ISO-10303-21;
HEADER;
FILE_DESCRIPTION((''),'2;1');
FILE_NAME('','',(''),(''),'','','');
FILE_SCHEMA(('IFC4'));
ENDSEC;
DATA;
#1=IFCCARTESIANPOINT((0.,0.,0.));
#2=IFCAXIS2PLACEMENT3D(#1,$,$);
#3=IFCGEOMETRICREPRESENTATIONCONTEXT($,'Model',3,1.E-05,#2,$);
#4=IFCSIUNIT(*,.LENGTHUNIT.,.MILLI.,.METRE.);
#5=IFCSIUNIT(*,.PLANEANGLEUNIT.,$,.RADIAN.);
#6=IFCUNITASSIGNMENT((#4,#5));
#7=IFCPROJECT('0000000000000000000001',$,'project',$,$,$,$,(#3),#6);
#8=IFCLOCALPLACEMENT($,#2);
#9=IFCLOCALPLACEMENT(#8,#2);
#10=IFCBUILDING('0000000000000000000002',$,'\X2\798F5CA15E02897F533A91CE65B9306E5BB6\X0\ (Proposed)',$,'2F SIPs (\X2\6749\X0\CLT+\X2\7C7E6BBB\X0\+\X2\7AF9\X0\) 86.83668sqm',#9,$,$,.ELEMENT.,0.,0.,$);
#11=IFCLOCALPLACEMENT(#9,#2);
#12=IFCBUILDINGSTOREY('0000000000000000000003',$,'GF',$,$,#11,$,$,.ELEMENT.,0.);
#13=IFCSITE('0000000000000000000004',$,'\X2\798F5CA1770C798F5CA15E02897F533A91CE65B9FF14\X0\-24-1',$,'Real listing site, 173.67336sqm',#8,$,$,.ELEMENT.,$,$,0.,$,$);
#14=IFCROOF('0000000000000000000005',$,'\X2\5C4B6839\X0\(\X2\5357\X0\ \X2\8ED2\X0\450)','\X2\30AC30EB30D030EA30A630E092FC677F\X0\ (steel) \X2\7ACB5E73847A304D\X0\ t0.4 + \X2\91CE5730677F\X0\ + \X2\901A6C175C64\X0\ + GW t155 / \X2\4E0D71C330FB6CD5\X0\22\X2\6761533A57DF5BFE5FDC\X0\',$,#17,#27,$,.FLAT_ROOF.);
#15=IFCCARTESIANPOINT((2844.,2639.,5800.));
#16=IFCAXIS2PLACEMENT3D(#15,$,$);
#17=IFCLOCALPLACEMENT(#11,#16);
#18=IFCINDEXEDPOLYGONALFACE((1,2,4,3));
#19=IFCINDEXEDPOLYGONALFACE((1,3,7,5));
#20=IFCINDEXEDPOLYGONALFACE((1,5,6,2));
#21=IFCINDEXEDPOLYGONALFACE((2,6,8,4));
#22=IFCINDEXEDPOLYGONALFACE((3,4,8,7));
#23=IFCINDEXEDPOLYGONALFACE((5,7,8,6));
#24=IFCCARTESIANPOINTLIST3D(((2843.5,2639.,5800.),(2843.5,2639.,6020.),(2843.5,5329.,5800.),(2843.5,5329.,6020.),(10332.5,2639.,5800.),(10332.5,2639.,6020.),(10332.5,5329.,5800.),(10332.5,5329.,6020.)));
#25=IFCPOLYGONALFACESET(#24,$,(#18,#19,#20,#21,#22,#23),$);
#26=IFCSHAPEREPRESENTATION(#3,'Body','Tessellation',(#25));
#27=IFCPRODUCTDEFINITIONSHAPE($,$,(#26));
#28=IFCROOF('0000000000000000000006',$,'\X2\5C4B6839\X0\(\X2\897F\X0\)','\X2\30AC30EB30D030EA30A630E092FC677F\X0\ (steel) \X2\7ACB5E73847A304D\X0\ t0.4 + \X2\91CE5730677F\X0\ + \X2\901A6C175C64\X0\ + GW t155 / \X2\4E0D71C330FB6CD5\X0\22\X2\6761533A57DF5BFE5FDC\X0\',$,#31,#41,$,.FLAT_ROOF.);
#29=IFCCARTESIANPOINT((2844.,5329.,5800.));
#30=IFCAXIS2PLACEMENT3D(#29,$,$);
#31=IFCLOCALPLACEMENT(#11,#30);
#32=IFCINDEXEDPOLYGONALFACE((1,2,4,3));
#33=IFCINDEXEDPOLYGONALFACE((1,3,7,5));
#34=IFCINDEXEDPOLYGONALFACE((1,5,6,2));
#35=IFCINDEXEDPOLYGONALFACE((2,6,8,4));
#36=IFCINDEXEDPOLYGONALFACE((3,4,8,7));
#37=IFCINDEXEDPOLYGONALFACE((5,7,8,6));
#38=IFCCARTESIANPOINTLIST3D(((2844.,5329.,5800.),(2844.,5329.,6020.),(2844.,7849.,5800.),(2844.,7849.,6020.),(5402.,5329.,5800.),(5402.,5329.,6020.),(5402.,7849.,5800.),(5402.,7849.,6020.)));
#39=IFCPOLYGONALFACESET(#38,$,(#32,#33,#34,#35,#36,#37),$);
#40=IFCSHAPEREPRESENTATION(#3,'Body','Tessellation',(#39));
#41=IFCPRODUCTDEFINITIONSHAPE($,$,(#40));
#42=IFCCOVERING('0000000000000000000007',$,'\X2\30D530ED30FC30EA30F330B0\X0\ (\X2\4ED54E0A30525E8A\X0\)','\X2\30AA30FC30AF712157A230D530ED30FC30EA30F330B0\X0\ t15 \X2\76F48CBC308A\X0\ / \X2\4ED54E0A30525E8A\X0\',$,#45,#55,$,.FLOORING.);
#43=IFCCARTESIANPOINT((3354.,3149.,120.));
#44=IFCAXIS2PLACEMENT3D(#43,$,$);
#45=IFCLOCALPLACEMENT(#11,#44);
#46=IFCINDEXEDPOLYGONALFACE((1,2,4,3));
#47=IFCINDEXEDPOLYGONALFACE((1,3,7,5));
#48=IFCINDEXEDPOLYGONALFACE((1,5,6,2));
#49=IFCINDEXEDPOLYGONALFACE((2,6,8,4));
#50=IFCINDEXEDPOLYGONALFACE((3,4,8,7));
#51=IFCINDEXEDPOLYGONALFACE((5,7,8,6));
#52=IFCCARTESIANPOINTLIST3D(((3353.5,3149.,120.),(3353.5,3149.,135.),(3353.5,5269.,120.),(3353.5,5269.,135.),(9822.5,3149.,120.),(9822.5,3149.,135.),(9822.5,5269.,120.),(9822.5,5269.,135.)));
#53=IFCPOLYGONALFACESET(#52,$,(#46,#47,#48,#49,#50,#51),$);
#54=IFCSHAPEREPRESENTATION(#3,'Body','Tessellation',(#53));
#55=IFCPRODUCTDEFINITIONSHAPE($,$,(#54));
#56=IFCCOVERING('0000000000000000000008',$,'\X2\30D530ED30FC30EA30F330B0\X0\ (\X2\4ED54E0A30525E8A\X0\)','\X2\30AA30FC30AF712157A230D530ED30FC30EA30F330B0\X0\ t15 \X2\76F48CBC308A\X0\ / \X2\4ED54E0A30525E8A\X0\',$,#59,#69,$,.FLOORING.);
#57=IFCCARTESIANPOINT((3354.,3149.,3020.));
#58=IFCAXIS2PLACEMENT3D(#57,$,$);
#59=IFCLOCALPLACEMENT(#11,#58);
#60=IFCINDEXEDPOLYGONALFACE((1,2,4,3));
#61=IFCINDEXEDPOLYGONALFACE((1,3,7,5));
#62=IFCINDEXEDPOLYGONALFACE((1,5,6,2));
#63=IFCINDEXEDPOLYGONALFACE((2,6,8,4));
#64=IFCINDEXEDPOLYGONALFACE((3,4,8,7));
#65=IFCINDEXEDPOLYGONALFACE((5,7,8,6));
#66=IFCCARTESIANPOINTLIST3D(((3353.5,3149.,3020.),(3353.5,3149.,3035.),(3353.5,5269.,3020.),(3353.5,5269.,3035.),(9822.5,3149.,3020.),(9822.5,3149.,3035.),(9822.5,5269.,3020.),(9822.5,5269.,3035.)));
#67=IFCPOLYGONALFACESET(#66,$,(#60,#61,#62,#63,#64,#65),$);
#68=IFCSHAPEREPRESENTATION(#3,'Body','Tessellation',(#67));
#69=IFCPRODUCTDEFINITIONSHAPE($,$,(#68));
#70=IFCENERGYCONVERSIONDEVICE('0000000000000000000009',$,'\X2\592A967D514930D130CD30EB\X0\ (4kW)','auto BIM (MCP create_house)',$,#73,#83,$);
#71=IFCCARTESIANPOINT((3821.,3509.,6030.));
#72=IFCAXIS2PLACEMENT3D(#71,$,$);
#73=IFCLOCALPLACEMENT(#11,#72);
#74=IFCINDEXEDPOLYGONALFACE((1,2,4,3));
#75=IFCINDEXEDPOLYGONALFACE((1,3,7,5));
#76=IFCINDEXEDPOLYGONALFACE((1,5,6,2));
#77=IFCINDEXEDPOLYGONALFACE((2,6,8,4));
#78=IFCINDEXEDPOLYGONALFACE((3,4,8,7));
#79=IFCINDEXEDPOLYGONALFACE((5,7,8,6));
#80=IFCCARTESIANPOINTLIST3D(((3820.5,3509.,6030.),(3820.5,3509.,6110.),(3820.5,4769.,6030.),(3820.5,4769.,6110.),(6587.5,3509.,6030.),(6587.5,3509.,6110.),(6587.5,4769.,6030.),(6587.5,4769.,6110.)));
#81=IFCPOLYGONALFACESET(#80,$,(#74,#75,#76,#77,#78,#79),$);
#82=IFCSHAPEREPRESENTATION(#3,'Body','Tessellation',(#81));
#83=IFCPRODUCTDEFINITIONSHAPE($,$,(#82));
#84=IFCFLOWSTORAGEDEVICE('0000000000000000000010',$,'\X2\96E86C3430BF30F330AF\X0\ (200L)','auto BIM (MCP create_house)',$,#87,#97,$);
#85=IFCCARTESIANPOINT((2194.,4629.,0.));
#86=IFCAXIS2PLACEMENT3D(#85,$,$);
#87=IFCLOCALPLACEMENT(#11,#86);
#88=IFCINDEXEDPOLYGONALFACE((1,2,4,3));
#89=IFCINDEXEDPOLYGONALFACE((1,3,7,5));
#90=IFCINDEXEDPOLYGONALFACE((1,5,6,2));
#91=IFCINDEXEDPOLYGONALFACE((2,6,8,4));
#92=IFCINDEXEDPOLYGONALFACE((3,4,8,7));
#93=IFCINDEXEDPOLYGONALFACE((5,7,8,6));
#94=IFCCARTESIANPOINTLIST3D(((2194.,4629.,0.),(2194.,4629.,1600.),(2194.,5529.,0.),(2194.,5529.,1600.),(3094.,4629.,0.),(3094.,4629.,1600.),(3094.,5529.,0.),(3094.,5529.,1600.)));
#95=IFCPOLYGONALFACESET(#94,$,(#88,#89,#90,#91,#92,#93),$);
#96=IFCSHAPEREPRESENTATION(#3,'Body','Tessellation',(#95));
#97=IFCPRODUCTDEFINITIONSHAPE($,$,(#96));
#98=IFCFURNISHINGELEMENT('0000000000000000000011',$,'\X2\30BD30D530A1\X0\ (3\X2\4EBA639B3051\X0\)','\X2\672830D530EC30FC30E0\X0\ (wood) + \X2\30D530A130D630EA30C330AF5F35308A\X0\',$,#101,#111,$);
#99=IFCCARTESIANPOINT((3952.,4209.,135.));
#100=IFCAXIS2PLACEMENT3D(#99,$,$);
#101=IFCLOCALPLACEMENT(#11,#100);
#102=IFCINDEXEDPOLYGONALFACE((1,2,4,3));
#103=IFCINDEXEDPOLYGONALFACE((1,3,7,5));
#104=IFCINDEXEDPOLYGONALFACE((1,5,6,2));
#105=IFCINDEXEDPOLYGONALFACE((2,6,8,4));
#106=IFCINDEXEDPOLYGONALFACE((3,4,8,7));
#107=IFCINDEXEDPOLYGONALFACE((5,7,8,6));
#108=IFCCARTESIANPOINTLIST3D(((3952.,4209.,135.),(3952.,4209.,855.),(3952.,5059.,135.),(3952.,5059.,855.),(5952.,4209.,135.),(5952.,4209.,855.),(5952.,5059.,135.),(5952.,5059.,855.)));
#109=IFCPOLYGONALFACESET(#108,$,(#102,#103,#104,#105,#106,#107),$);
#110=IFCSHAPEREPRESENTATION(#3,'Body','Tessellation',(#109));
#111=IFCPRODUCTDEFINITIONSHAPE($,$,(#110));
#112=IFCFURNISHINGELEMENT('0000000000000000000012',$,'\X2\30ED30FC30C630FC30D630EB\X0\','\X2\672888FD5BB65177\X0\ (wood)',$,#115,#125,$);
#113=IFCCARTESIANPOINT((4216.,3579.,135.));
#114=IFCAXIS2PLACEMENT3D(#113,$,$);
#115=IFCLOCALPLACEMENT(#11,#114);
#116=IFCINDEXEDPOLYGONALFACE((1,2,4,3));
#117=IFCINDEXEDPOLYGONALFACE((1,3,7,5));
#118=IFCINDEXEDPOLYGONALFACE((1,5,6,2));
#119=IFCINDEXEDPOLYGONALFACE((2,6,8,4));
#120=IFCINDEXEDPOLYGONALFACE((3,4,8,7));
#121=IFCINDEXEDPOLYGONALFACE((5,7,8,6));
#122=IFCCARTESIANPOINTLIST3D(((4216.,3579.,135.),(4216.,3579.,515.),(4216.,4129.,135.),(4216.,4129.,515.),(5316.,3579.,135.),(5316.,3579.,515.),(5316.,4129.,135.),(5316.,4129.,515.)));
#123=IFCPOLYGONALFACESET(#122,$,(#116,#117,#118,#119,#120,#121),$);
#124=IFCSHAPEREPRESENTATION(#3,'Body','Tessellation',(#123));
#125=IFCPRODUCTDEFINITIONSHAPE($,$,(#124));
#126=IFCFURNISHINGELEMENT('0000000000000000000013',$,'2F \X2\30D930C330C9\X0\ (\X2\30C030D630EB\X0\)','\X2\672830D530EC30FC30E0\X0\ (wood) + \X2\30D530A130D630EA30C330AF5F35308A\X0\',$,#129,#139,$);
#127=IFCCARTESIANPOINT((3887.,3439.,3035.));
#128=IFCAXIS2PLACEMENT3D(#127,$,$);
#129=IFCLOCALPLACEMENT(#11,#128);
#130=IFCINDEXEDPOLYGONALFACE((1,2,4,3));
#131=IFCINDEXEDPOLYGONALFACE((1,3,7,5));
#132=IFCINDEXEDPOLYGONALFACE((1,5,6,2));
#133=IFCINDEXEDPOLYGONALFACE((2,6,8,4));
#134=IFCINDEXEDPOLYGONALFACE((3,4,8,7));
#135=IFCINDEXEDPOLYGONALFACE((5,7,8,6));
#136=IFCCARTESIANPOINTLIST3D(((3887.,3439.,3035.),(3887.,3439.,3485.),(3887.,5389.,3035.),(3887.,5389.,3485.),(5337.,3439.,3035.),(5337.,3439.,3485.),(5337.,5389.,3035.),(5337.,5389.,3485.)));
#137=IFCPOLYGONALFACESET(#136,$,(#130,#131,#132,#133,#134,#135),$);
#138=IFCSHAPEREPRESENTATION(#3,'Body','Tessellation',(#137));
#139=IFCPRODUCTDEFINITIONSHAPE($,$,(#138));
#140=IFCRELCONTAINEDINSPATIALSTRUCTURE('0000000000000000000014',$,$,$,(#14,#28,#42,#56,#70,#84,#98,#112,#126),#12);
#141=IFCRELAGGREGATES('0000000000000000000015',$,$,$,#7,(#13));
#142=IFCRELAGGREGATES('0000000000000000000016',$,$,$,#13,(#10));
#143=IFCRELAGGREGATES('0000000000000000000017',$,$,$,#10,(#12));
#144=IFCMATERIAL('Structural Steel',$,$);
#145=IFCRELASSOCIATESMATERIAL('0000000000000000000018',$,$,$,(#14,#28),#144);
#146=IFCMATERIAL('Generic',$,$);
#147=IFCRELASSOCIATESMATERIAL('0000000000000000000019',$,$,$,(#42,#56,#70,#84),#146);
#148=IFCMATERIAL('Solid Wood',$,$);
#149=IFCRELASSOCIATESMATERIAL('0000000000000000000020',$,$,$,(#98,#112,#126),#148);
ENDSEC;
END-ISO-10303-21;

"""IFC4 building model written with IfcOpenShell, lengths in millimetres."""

from ifc_helpers import new_model, si_unit, frame, frame_2d, origin, place, context, project, spatial, rectangle, extrude, material, element, save


model = new_model("IFC4")

# Units and contexts
model_context = context("Model", 3, precision=1e-05, world=origin())
ifc_project = project(units=[si_unit("LENGTHUNIT", "METRE", prefix="MILLI"), si_unit("PLANEANGLEUNIT", "RADIAN")], contexts=[model_context])

# Site, building, storey
site_placement = place(None, origin())
site = spatial("IfcSite", under=ifc_project, at=site_placement, Name="福岡県福岡市西区野方４-24-1", ObjectType="Real listing site, 173.67336sqm", CompositionType="ELEMENT", RefElevation=0.0)
building_placement = place(site_placement, origin())
building = spatial("IfcBuilding", under=site, at=building_placement, Name="福岡市西区野方の家 (Proposed)", ObjectType="2F SIPs (杉CLT+籾殻+竹) 86.83668sqm", CompositionType="ELEMENT", ElevationOfRefHeight=0.0, ElevationOfTerrain=0.0)
storey_placement = place(building_placement, origin())
storey = spatial("IfcBuildingStorey", under=building, at=storey_placement, Name="GF", CompositionType="ELEMENT", Elevation=0.0)

# Shared definitions
ifc_material_1 = material(Name="Solid Wood")

# Roofs
ifc_material_2 = material(Name="Structural Steel")
roof_1_placement = place(storey_placement, frame((2844.0, 2639.0, 5800.0)))
element("IfcRoof", 1, at=roof_1_placement, inside=storey, material=ifc_material_2, Name="屋根(南 軒450)", Description="ガルバリウム鋼板 (steel) 立平葺き t0.4 + 野地板 + 通気層 + GW t155 / 不燃・法22条区域対応", PredefinedType="FLAT_ROOF", context=model_context, shape_type="SweptSolid", body=[
    extrude(rectangle(XDim=7489.0, YDim=2690.0, at=frame_2d((3744.0, 1345.0))), frame((2844.0, 2639.0, 5800.0)), (0.0, 0.0, 1.0), 220.0),
])
roof_2_placement = place(storey_placement, frame((2844.0, 5329.0, 5800.0)))
element("IfcRoof", 2, at=roof_2_placement, inside=storey, material=ifc_material_2, Name="屋根(西)", Description="ガルバリウム鋼板 (steel) 立平葺き t0.4 + 野地板 + 通気層 + GW t155 / 不燃・法22条区域対応", PredefinedType="FLAT_ROOF", context=model_context, shape_type="SweptSolid", body=[
    extrude(rectangle(XDim=2558.0, YDim=2520.0, at=frame_2d((1279.0, 1260.0))), frame((2844.0, 5329.0, 5800.0)), (0.0, 0.0, 1.0), 220.0),
])

# Coverings
ifc_material_3 = material(Name="Generic")
covering_1_placement = place(storey_placement, frame((3354.0, 3149.0, 120.0)))
element("IfcCovering", 3, at=covering_1_placement, inside=storey, material=ifc_material_3, Name="フローリング (仕上げ床)", Description="オーク無垢フローリング t15 直貼り / 仕上げ床", PredefinedType="FLOORING", context=model_context, shape_type="SweptSolid", body=[
    extrude(rectangle(XDim=6469.0, YDim=2120.0, at=frame_2d((3234.0, 1060.0))), frame((3354.0, 3149.0, 120.0)), (0.0, 0.0, 1.0), 15.0),
])
covering_2_placement = place(storey_placement, frame((3354.0, 3149.0, 3020.0)))
element("IfcCovering", 4, at=covering_2_placement, inside=storey, material=ifc_material_3, Name="フローリング (仕上げ床)", Description="オーク無垢フローリング t15 直貼り / 仕上げ床", PredefinedType="FLOORING", context=model_context, shape_type="SweptSolid", body=[
    extrude(rectangle(XDim=6469.0, YDim=2120.0, at=frame_2d((3234.0, 1060.0))), frame((3354.0, 3149.0, 3020.0)), (0.0, 0.0, 1.0), 15.0),
])

# Energy conversion device
energy_conversion_device_placement = place(storey_placement, frame((3821.0, 3509.0, 6030.0)))
element("IfcEnergyConversionDevice", 5, at=energy_conversion_device_placement, inside=storey, material=ifc_material_3, Name="太陽光パネル (4kW)", Description="auto BIM (MCP create_house)", context=model_context, shape_type="SweptSolid", body=[
    extrude(rectangle(XDim=2767.0, YDim=1260.0, at=frame_2d((1383.0, 630.0))), frame((3821.0, 3509.0, 6030.0)), (0.0, 0.0, 1.0), 80.0),
])

# Flow storage device
flow_storage_device_placement = place(storey_placement, frame((2194.0, 4629.0, 0.0)))
element("IfcFlowStorageDevice", 6, at=flow_storage_device_placement, inside=storey, material=ifc_material_3, Name="雨水タンク (200L)", Description="auto BIM (MCP create_house)", context=model_context, shape_type="SweptSolid", body=[
    extrude(rectangle(XDim=900.0, YDim=900.0, at=frame_2d((450.0, 450.0))), frame((2194.0, 4629.0, 0.0)), (0.0, 0.0, 1.0), 1600.0),
])

# Furnishing elements
furnishing_1_placement = place(storey_placement, frame((3952.0, 4209.0, 135.0)))
element("IfcFurnishingElement", 7, at=furnishing_1_placement, inside=storey, material=ifc_material_1, Name="ソファ (3人掛け)", Description="木フレーム (wood) + ファブリック張り", context=model_context, shape_type="SweptSolid", body=[
    extrude(rectangle(XDim=2000.0, YDim=850.0, at=frame_2d((1000.0, 425.0))), frame((3952.0, 4209.0, 135.0)), (0.0, 0.0, 1.0), 720.0),
])
furnishing_2_placement = place(storey_placement, frame((4216.0, 3579.0, 135.0)))
element("IfcFurnishingElement", 8, at=furnishing_2_placement, inside=storey, material=ifc_material_1, Name="ローテーブル", Description="木製家具 (wood)", context=model_context, shape_type="SweptSolid", body=[
    extrude(rectangle(XDim=1100.0, YDim=550.0, at=frame_2d((550.0, 275.0))), frame((4216.0, 3579.0, 135.0)), (0.0, 0.0, 1.0), 380.0),
])
furnishing_3_placement = place(storey_placement, frame((3887.0, 3439.0, 3035.0)))
element("IfcFurnishingElement", 9, at=furnishing_3_placement, inside=storey, material=ifc_material_1, Name="2F ベッド (ダブル)", Description="木フレーム (wood) + ファブリック張り", context=model_context, shape_type="SweptSolid", body=[
    extrude(rectangle(XDim=1450.0, YDim=1950.0, at=frame_2d((725.0, 975.0))), frame((3887.0, 3439.0, 3035.0)), (0.0, 0.0, 1.0), 450.0),
])

save(model, "model.ifc")
